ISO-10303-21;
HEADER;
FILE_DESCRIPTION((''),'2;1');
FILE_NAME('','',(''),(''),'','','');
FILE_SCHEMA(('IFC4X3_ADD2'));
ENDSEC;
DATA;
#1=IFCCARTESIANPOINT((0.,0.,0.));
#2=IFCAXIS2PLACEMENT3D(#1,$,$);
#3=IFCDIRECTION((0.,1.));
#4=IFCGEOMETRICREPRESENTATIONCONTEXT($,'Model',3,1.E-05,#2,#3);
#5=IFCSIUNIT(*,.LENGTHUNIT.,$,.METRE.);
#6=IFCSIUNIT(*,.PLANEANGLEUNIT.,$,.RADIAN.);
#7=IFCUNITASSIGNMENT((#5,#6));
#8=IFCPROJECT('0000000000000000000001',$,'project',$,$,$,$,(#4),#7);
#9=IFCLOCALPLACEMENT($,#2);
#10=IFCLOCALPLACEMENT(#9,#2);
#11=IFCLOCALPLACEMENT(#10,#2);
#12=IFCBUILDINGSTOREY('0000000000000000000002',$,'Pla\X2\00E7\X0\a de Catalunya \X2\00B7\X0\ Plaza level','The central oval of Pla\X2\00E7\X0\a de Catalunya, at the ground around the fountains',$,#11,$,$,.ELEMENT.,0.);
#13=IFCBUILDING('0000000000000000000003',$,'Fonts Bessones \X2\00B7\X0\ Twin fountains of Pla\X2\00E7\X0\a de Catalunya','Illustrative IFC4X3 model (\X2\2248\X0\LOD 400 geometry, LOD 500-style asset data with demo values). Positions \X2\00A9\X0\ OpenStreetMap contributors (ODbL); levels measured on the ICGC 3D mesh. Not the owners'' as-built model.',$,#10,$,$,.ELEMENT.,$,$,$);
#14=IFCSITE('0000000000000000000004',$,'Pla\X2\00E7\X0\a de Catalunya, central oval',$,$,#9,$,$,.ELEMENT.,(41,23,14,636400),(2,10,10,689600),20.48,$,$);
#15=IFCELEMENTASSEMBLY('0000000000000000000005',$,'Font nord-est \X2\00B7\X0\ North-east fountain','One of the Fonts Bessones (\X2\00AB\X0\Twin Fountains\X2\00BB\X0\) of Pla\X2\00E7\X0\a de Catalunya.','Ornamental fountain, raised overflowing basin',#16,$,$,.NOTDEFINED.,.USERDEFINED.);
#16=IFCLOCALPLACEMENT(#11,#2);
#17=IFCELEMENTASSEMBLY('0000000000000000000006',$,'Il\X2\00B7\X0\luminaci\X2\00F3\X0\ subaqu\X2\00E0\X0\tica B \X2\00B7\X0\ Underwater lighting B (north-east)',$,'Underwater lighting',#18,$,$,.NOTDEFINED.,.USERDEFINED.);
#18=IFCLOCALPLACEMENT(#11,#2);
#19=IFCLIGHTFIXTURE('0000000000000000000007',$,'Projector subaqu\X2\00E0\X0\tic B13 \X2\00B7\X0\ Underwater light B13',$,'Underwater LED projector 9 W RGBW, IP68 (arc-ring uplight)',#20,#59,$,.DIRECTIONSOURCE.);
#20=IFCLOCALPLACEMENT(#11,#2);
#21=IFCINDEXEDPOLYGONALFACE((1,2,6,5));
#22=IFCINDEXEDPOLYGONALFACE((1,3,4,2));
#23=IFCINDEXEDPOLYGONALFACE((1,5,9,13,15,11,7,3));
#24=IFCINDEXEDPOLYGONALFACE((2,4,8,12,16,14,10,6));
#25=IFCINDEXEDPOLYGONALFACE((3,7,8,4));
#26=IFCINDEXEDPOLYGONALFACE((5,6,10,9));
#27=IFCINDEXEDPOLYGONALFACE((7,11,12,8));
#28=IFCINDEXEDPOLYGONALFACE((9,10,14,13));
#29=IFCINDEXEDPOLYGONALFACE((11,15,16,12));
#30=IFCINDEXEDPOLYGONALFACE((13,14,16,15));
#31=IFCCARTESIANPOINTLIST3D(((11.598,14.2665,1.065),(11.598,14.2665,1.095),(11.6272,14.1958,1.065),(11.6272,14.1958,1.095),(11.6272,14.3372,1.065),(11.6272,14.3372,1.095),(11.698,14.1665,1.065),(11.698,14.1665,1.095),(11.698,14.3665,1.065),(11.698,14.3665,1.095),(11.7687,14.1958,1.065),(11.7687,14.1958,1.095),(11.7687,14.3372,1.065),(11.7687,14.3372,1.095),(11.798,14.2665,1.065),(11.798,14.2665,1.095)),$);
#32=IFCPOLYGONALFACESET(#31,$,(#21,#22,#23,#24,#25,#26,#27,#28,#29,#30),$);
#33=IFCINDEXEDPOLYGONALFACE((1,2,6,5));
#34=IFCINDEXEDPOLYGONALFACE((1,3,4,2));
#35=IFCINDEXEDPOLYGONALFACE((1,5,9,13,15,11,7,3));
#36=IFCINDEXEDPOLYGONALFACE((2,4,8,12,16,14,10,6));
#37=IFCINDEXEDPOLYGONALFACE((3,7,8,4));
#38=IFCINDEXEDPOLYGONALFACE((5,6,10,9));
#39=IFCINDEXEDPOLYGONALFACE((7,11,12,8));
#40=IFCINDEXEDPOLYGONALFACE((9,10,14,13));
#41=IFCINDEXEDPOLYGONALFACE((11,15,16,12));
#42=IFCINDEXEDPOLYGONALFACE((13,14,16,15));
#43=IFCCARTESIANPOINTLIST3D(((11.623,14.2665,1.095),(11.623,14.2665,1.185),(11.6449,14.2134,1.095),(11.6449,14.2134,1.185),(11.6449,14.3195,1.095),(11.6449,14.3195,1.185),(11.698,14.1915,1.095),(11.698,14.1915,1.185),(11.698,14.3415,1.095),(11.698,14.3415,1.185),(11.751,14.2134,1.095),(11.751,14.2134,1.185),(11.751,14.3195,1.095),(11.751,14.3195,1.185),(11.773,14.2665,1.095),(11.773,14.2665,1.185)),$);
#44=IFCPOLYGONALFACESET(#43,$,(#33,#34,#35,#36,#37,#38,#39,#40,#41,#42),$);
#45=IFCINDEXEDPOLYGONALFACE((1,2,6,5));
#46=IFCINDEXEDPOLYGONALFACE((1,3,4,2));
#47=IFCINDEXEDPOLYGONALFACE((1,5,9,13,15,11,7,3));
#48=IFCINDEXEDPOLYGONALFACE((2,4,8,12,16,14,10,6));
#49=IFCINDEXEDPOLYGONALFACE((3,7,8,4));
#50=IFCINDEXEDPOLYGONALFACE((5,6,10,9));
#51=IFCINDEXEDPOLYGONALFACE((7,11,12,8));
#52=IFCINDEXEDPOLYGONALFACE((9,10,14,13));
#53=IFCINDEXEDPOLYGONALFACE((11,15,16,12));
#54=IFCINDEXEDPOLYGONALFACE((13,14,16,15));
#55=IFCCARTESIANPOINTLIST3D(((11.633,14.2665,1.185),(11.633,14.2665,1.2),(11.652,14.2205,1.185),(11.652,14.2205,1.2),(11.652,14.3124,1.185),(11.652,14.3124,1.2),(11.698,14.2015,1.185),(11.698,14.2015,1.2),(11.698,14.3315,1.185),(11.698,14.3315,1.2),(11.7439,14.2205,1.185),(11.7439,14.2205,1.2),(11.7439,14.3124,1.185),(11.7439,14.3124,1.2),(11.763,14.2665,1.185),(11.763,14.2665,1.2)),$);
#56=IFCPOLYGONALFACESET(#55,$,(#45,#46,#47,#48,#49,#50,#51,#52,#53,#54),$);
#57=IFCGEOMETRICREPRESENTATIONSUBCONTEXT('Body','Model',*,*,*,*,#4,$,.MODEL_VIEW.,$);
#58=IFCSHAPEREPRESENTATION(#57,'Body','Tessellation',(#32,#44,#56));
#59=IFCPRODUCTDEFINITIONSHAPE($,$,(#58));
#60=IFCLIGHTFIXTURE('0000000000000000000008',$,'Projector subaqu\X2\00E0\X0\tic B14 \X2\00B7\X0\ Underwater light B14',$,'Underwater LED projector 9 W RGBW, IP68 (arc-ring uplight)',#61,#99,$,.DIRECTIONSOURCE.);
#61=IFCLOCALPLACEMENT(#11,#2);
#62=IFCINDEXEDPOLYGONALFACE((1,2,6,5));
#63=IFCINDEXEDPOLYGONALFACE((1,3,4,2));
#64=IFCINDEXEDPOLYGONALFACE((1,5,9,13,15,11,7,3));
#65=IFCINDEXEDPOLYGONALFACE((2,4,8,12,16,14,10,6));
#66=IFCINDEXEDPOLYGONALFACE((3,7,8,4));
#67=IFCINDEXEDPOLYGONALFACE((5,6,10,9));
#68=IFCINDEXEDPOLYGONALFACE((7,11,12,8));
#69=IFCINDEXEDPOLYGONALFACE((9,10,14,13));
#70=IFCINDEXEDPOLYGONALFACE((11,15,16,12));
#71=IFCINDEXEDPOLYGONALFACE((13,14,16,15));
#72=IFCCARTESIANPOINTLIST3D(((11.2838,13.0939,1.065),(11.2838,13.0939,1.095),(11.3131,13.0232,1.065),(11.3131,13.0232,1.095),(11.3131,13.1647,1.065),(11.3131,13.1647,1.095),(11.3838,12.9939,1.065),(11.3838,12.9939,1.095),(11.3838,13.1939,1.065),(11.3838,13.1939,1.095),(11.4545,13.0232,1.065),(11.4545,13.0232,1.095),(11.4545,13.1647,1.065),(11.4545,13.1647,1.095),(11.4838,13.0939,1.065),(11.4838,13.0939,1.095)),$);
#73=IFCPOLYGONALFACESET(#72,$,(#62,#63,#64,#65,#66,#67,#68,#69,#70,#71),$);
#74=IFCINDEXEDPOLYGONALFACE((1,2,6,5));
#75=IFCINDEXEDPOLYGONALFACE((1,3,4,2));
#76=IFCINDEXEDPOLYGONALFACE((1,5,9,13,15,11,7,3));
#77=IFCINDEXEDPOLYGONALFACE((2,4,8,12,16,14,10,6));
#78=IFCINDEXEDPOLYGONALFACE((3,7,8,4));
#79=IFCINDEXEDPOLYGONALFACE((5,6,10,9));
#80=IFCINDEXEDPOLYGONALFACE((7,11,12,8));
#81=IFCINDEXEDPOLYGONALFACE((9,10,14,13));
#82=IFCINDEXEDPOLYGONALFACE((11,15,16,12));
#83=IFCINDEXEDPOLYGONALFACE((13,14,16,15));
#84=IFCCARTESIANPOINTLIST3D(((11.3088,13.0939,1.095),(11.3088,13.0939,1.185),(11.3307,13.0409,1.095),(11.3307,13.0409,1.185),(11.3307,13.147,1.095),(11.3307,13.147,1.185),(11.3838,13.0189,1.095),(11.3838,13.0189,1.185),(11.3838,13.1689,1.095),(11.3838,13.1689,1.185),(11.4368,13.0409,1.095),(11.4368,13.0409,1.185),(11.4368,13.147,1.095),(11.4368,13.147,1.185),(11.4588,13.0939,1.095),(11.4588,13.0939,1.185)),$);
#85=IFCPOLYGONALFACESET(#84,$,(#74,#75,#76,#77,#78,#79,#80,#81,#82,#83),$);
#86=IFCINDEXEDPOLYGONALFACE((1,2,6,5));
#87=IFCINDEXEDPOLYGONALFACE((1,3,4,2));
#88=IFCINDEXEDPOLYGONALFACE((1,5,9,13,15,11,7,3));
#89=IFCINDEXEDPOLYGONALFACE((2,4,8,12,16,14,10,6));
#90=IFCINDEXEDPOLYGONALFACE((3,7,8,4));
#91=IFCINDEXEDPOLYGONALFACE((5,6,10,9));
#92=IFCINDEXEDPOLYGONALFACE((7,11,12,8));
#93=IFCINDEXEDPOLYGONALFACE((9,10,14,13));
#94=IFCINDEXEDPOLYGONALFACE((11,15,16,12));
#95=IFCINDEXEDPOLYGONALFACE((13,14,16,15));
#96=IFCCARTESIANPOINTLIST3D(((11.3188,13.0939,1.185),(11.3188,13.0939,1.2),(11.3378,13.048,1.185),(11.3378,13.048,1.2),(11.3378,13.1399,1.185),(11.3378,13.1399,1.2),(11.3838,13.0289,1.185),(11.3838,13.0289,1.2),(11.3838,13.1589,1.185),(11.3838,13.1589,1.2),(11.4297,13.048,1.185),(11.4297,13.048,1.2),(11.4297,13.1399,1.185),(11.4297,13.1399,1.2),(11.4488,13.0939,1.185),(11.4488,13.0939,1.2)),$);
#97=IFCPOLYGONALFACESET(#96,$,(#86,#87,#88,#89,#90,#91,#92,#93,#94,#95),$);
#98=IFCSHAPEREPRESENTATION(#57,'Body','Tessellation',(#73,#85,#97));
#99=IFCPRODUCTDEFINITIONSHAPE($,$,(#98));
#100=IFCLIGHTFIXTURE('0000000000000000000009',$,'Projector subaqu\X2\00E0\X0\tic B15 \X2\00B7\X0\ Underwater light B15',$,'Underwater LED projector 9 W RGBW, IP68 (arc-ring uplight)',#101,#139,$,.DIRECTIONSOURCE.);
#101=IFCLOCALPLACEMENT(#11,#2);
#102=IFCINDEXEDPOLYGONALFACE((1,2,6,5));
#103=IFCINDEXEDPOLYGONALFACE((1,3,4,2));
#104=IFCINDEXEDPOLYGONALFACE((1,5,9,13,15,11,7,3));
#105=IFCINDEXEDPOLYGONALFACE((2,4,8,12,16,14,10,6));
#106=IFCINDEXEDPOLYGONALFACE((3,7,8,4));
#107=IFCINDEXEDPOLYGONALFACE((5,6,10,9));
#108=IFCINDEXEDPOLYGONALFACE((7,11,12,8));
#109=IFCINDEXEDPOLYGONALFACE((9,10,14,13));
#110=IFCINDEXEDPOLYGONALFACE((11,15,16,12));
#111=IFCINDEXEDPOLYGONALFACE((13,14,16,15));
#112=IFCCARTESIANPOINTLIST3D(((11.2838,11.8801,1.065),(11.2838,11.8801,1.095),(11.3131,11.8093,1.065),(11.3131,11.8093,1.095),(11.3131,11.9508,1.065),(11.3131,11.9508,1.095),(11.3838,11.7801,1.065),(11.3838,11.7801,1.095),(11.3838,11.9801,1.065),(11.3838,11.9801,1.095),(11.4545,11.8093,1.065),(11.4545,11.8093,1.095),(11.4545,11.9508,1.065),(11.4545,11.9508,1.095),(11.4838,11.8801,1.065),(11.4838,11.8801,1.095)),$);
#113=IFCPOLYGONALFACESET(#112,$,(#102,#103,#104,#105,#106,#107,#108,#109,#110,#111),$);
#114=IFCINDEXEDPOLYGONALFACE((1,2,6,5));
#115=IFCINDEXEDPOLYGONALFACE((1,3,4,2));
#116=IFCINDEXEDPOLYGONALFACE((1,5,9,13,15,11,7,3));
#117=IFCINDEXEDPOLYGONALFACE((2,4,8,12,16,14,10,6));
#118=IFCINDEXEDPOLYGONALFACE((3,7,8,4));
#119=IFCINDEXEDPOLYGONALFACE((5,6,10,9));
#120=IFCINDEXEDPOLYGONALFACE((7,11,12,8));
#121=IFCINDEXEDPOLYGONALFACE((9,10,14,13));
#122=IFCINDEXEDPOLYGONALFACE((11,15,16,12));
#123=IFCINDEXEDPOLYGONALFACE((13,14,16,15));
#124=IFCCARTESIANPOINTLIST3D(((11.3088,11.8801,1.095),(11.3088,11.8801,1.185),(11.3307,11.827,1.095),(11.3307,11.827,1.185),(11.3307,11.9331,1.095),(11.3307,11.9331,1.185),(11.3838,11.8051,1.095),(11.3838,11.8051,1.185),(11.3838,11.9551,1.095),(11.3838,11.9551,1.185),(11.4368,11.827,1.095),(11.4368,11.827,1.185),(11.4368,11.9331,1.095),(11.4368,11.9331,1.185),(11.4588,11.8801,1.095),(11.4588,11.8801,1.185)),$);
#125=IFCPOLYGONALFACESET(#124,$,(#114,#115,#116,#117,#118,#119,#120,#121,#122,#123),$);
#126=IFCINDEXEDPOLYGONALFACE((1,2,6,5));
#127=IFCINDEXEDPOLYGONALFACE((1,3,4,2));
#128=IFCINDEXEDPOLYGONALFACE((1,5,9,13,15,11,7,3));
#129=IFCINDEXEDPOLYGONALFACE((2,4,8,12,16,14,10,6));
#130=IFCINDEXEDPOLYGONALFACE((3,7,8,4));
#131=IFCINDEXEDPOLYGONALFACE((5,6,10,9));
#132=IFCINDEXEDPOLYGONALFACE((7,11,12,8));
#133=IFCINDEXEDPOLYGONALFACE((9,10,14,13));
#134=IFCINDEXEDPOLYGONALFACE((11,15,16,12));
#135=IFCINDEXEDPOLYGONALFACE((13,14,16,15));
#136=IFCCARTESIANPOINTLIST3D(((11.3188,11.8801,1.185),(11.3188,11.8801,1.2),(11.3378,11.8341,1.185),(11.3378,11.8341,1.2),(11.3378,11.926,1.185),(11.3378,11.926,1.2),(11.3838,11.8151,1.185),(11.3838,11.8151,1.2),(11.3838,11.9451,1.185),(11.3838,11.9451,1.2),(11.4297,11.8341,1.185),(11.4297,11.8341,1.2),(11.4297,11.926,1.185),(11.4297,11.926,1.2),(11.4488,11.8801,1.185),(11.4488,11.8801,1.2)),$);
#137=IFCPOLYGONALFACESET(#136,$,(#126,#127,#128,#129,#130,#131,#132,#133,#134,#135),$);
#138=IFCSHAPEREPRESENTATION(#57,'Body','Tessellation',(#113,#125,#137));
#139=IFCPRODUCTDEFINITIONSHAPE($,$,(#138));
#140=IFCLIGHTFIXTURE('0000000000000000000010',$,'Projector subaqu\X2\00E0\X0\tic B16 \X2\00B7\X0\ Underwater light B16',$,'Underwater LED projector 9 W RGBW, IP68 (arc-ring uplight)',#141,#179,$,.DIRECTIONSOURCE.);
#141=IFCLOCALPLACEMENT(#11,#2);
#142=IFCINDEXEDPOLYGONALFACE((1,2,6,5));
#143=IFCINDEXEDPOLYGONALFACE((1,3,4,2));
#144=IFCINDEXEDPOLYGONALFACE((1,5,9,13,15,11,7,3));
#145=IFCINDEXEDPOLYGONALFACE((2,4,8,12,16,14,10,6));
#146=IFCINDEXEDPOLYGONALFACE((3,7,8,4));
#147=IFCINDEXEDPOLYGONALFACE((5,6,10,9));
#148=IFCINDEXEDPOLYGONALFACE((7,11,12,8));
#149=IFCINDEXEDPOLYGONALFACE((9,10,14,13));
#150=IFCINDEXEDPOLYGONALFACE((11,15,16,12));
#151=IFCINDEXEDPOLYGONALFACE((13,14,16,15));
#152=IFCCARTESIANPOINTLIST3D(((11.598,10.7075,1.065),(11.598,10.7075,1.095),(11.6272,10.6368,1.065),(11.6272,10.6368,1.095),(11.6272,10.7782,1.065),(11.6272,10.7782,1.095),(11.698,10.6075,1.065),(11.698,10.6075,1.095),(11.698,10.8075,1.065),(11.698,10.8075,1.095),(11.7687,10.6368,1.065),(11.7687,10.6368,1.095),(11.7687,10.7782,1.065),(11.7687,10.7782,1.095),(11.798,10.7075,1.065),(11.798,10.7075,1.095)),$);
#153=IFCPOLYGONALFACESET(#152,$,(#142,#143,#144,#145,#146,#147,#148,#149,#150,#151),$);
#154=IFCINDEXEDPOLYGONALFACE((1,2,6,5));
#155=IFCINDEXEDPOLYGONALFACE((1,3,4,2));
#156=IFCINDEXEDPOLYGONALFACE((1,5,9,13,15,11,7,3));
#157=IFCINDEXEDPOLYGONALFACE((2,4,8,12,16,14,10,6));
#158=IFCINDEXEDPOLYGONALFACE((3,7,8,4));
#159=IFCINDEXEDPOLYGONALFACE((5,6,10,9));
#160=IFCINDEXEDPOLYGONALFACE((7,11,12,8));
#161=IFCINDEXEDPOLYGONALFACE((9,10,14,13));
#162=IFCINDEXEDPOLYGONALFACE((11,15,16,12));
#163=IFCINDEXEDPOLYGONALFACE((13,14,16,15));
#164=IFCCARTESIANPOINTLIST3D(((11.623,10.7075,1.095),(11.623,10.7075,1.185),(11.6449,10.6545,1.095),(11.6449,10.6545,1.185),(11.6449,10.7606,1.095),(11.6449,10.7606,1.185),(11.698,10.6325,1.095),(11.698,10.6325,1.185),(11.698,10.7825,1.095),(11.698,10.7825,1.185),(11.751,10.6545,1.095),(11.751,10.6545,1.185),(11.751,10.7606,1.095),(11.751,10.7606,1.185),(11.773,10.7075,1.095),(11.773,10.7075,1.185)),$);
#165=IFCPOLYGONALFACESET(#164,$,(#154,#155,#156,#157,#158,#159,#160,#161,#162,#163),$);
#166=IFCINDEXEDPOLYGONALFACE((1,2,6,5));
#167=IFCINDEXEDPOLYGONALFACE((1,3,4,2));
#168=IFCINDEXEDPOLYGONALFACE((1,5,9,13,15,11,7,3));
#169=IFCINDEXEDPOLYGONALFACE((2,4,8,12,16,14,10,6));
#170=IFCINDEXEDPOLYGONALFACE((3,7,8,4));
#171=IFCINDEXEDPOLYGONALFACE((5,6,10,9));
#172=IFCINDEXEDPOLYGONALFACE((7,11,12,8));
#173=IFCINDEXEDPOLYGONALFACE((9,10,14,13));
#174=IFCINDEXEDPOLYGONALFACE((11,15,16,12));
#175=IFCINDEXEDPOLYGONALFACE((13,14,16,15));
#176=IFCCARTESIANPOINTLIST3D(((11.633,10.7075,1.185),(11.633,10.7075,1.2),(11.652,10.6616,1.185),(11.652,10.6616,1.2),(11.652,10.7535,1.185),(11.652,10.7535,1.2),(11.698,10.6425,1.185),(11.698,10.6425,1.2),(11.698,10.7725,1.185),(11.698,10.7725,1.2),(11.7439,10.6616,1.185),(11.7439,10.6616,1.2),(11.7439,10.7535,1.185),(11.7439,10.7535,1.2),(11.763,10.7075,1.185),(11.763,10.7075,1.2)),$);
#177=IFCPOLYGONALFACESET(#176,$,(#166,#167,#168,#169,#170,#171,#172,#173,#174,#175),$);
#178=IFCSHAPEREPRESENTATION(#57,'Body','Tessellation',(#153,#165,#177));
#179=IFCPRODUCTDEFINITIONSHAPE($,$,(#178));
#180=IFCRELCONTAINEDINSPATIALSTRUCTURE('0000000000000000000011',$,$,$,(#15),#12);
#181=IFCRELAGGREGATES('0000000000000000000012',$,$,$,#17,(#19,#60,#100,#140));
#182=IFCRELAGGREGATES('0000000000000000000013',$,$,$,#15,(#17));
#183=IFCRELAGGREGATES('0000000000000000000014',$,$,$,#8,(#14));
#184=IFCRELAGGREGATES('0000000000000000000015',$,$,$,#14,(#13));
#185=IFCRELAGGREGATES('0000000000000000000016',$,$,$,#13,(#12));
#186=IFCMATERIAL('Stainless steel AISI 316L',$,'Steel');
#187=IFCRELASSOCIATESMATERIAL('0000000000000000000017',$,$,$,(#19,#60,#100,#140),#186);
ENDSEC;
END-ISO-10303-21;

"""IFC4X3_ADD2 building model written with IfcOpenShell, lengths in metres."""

from ifc_helpers import new_model, si_unit, direction, frame, origin, place, context, subcontext, project, spatial, polyline, outline, extrude, material, element, aggregate, save


model = new_model("IFC4X3_ADD2")

# Units and contexts
model_context = context("Model", 3, precision=1e-05, world=origin(), true_north=direction((0.0, 1.0)))
body_context = subcontext(model_context, "Body", "Model", "MODEL_VIEW")
ifc_project = project(units=[si_unit("LENGTHUNIT", "METRE"), si_unit("PLANEANGLEUNIT", "RADIAN")], contexts=[model_context])

# Site, building, storey
site_placement = place(None, origin())
site = spatial("IfcSite", under=ifc_project, at=site_placement, Name="Plaça de Catalunya, central oval", CompositionType="ELEMENT", RefLatitude=(41, 23, 14, 636400), RefLongitude=(2, 10, 10, 689600), RefElevation=20.48)
building_placement = place(site_placement, origin())
building = spatial("IfcBuilding", under=site, at=building_placement, Name="Fonts Bessones · Twin fountains of Plaça de Catalunya", Description="Illustrative IFC4X3 model (≈LOD 400 geometry, LOD 500-style asset data with demo values). Positions © OpenStreetMap contributors (ODbL); levels measured on the ICGC 3D mesh. Not the owners' as-built model.", CompositionType="ELEMENT")
storey_placement = place(building_placement, origin())
storey = spatial("IfcBuildingStorey", under=building, at=storey_placement, Name="Plaça de Catalunya · Plaza level", Description="The central oval of Plaça de Catalunya, at the ground around the fountains", CompositionType="ELEMENT", Elevation=0.0)

# Element assemblies, light fixtures
assembly_1_placement = place(building_placement, origin())
assembly_1 = element("IfcElementAssembly", 1, at=assembly_1_placement, inside=storey, Name="Font nord-est · North-east fountain", Description="One of the Fonts Bessones («Twin Fountains») of Plaça de Catalunya.", ObjectType="Ornamental fountain, raised overflowing basin", AssemblyPlace="NOTDEFINED", PredefinedType="USERDEFINED")
assembly_2_placement = place(building_placement, origin())
assembly_2 = element("IfcElementAssembly", 2, at=assembly_2_placement, Name="Il·luminació subaquàtica B · Underwater lighting B (north-east)", ObjectType="Underwater lighting", AssemblyPlace="NOTDEFINED", PredefinedType="USERDEFINED")
ifc_material_1 = material(Name="Stainless steel AISI 316L", Category="Steel")
light_fixture_1_placement = place(building_placement, origin())
light_fixture_1 = element("IfcLightFixture", 3, at=light_fixture_1_placement, material=ifc_material_1, Name="Projector subaquàtic B13 · Underwater light B13", ObjectType="Underwater LED projector 9 W RGBW, IP68 (arc-ring uplight)", PredefinedType="DIRECTIONSOURCE", context=body_context, shape_type="SweptSolid", body=[
    extrude(outline(polyline([(11.798, 14.2665), (11.7687, 14.3372), (11.698, 14.3665), (11.6272, 14.3372), (11.598, 14.2665), (11.6272, 14.1958), (11.698, 14.1665), (11.7687, 14.1958), (11.798, 14.2665)])), frame((0.0, 0.0, 1.065)), (0.0, 0.0, 1.0), 0.03),
    extrude(outline(polyline([(11.773, 14.2665), (11.751, 14.3195), (11.698, 14.3415), (11.6449, 14.3195), (11.623, 14.2665), (11.6449, 14.2134), (11.698, 14.1915), (11.751, 14.2134), (11.773, 14.2665)])), frame((0.0, 0.0, 1.095)), (0.0, 0.0, 1.0), 0.09),
    extrude(outline(polyline([(11.763, 14.2665), (11.7439, 14.3124), (11.698, 14.3315), (11.652, 14.3124), (11.633, 14.2665), (11.652, 14.2205), (11.698, 14.2015), (11.7439, 14.2205), (11.763, 14.2665)])), frame((0.0, 0.0, 1.185)), (0.0, 0.0, 1.0), 0.015),
])
light_fixture_2_placement = place(building_placement, origin())
light_fixture_2 = element("IfcLightFixture", 4, at=light_fixture_2_placement, material=ifc_material_1, Name="Projector subaquàtic B14 · Underwater light B14", ObjectType="Underwater LED projector 9 W RGBW, IP68 (arc-ring uplight)", PredefinedType="DIRECTIONSOURCE", context=body_context, shape_type="SweptSolid", body=[
    extrude(outline(polyline([(11.4838, 13.0939), (11.4545, 13.1647), (11.3838, 13.1939), (11.3131, 13.1647), (11.2838, 13.0939), (11.3131, 13.0232), (11.3838, 12.9939), (11.4545, 13.0232), (11.4838, 13.0939)])), frame((0.0, 0.0, 1.065)), (0.0, 0.0, 1.0), 0.03),
    extrude(outline(polyline([(11.4588, 13.0939), (11.4368, 13.147), (11.3838, 13.1689), (11.3307, 13.147), (11.3088, 13.0939), (11.3307, 13.0409), (11.3838, 13.0189), (11.4368, 13.0409), (11.4588, 13.0939)])), frame((0.0, 0.0, 1.095)), (0.0, 0.0, 1.0), 0.09),
    extrude(outline(polyline([(11.4488, 13.0939), (11.4297, 13.1399), (11.3838, 13.1589), (11.3378, 13.1399), (11.3188, 13.0939), (11.3378, 13.048), (11.3838, 13.0289), (11.4297, 13.048), (11.4488, 13.0939)])), frame((0.0, 0.0, 1.185)), (0.0, 0.0, 1.0), 0.015),
])
light_fixture_3_placement = place(building_placement, origin())
light_fixture_3 = element("IfcLightFixture", 5, at=light_fixture_3_placement, material=ifc_material_1, Name="Projector subaquàtic B15 · Underwater light B15", ObjectType="Underwater LED projector 9 W RGBW, IP68 (arc-ring uplight)", PredefinedType="DIRECTIONSOURCE", context=body_context, shape_type="SweptSolid", body=[
    extrude(outline(polyline([(11.4838, 11.8801), (11.4545, 11.9508), (11.3838, 11.9801), (11.3131, 11.9508), (11.2838, 11.8801), (11.3131, 11.8093), (11.3838, 11.7801), (11.4545, 11.8093), (11.4838, 11.8801)])), frame((0.0, 0.0, 1.065)), (0.0, 0.0, 1.0), 0.03),
    extrude(outline(polyline([(11.4588, 11.8801), (11.4368, 11.9331), (11.3838, 11.9551), (11.3307, 11.9331), (11.3088, 11.8801), (11.3307, 11.827), (11.3838, 11.8051), (11.4368, 11.827), (11.4588, 11.8801)])), frame((0.0, 0.0, 1.095)), (0.0, 0.0, 1.0), 0.09),
    extrude(outline(polyline([(11.4488, 11.8801), (11.4297, 11.926), (11.3838, 11.9451), (11.3378, 11.926), (11.3188, 11.8801), (11.3378, 11.8341), (11.3838, 11.8151), (11.4297, 11.8341), (11.4488, 11.8801)])), frame((0.0, 0.0, 1.185)), (0.0, 0.0, 1.0), 0.015),
])
light_fixture_4_placement = place(building_placement, origin())
light_fixture_4 = element("IfcLightFixture", 6, at=light_fixture_4_placement, material=ifc_material_1, Name="Projector subaquàtic B16 · Underwater light B16", ObjectType="Underwater LED projector 9 W RGBW, IP68 (arc-ring uplight)", PredefinedType="DIRECTIONSOURCE", context=body_context, shape_type="SweptSolid", body=[
    extrude(outline(polyline([(11.798, 10.7075), (11.7687, 10.7782), (11.698, 10.8075), (11.6272, 10.7782), (11.598, 10.7075), (11.6272, 10.6368), (11.698, 10.6075), (11.7687, 10.6368), (11.798, 10.7075)])), frame((0.0, 0.0, 1.065)), (0.0, 0.0, 1.0), 0.03),
    extrude(outline(polyline([(11.773, 10.7075), (11.751, 10.7606), (11.698, 10.7825), (11.6449, 10.7606), (11.623, 10.7075), (11.6449, 10.6545), (11.698, 10.6325), (11.751, 10.6545), (11.773, 10.7075)])), frame((0.0, 0.0, 1.095)), (0.0, 0.0, 1.0), 0.09),
    extrude(outline(polyline([(11.763, 10.7075), (11.7439, 10.7535), (11.698, 10.7725), (11.652, 10.7535), (11.633, 10.7075), (11.652, 10.6616), (11.698, 10.6425), (11.7439, 10.6616), (11.763, 10.7075)])), frame((0.0, 0.0, 1.185)), (0.0, 0.0, 1.0), 0.015),
])
aggregate(assembly_2, [light_fixture_1, light_fixture_2, light_fixture_3, light_fixture_4])
aggregate(assembly_1, [assembly_2])

save(model, "model.ifc")
